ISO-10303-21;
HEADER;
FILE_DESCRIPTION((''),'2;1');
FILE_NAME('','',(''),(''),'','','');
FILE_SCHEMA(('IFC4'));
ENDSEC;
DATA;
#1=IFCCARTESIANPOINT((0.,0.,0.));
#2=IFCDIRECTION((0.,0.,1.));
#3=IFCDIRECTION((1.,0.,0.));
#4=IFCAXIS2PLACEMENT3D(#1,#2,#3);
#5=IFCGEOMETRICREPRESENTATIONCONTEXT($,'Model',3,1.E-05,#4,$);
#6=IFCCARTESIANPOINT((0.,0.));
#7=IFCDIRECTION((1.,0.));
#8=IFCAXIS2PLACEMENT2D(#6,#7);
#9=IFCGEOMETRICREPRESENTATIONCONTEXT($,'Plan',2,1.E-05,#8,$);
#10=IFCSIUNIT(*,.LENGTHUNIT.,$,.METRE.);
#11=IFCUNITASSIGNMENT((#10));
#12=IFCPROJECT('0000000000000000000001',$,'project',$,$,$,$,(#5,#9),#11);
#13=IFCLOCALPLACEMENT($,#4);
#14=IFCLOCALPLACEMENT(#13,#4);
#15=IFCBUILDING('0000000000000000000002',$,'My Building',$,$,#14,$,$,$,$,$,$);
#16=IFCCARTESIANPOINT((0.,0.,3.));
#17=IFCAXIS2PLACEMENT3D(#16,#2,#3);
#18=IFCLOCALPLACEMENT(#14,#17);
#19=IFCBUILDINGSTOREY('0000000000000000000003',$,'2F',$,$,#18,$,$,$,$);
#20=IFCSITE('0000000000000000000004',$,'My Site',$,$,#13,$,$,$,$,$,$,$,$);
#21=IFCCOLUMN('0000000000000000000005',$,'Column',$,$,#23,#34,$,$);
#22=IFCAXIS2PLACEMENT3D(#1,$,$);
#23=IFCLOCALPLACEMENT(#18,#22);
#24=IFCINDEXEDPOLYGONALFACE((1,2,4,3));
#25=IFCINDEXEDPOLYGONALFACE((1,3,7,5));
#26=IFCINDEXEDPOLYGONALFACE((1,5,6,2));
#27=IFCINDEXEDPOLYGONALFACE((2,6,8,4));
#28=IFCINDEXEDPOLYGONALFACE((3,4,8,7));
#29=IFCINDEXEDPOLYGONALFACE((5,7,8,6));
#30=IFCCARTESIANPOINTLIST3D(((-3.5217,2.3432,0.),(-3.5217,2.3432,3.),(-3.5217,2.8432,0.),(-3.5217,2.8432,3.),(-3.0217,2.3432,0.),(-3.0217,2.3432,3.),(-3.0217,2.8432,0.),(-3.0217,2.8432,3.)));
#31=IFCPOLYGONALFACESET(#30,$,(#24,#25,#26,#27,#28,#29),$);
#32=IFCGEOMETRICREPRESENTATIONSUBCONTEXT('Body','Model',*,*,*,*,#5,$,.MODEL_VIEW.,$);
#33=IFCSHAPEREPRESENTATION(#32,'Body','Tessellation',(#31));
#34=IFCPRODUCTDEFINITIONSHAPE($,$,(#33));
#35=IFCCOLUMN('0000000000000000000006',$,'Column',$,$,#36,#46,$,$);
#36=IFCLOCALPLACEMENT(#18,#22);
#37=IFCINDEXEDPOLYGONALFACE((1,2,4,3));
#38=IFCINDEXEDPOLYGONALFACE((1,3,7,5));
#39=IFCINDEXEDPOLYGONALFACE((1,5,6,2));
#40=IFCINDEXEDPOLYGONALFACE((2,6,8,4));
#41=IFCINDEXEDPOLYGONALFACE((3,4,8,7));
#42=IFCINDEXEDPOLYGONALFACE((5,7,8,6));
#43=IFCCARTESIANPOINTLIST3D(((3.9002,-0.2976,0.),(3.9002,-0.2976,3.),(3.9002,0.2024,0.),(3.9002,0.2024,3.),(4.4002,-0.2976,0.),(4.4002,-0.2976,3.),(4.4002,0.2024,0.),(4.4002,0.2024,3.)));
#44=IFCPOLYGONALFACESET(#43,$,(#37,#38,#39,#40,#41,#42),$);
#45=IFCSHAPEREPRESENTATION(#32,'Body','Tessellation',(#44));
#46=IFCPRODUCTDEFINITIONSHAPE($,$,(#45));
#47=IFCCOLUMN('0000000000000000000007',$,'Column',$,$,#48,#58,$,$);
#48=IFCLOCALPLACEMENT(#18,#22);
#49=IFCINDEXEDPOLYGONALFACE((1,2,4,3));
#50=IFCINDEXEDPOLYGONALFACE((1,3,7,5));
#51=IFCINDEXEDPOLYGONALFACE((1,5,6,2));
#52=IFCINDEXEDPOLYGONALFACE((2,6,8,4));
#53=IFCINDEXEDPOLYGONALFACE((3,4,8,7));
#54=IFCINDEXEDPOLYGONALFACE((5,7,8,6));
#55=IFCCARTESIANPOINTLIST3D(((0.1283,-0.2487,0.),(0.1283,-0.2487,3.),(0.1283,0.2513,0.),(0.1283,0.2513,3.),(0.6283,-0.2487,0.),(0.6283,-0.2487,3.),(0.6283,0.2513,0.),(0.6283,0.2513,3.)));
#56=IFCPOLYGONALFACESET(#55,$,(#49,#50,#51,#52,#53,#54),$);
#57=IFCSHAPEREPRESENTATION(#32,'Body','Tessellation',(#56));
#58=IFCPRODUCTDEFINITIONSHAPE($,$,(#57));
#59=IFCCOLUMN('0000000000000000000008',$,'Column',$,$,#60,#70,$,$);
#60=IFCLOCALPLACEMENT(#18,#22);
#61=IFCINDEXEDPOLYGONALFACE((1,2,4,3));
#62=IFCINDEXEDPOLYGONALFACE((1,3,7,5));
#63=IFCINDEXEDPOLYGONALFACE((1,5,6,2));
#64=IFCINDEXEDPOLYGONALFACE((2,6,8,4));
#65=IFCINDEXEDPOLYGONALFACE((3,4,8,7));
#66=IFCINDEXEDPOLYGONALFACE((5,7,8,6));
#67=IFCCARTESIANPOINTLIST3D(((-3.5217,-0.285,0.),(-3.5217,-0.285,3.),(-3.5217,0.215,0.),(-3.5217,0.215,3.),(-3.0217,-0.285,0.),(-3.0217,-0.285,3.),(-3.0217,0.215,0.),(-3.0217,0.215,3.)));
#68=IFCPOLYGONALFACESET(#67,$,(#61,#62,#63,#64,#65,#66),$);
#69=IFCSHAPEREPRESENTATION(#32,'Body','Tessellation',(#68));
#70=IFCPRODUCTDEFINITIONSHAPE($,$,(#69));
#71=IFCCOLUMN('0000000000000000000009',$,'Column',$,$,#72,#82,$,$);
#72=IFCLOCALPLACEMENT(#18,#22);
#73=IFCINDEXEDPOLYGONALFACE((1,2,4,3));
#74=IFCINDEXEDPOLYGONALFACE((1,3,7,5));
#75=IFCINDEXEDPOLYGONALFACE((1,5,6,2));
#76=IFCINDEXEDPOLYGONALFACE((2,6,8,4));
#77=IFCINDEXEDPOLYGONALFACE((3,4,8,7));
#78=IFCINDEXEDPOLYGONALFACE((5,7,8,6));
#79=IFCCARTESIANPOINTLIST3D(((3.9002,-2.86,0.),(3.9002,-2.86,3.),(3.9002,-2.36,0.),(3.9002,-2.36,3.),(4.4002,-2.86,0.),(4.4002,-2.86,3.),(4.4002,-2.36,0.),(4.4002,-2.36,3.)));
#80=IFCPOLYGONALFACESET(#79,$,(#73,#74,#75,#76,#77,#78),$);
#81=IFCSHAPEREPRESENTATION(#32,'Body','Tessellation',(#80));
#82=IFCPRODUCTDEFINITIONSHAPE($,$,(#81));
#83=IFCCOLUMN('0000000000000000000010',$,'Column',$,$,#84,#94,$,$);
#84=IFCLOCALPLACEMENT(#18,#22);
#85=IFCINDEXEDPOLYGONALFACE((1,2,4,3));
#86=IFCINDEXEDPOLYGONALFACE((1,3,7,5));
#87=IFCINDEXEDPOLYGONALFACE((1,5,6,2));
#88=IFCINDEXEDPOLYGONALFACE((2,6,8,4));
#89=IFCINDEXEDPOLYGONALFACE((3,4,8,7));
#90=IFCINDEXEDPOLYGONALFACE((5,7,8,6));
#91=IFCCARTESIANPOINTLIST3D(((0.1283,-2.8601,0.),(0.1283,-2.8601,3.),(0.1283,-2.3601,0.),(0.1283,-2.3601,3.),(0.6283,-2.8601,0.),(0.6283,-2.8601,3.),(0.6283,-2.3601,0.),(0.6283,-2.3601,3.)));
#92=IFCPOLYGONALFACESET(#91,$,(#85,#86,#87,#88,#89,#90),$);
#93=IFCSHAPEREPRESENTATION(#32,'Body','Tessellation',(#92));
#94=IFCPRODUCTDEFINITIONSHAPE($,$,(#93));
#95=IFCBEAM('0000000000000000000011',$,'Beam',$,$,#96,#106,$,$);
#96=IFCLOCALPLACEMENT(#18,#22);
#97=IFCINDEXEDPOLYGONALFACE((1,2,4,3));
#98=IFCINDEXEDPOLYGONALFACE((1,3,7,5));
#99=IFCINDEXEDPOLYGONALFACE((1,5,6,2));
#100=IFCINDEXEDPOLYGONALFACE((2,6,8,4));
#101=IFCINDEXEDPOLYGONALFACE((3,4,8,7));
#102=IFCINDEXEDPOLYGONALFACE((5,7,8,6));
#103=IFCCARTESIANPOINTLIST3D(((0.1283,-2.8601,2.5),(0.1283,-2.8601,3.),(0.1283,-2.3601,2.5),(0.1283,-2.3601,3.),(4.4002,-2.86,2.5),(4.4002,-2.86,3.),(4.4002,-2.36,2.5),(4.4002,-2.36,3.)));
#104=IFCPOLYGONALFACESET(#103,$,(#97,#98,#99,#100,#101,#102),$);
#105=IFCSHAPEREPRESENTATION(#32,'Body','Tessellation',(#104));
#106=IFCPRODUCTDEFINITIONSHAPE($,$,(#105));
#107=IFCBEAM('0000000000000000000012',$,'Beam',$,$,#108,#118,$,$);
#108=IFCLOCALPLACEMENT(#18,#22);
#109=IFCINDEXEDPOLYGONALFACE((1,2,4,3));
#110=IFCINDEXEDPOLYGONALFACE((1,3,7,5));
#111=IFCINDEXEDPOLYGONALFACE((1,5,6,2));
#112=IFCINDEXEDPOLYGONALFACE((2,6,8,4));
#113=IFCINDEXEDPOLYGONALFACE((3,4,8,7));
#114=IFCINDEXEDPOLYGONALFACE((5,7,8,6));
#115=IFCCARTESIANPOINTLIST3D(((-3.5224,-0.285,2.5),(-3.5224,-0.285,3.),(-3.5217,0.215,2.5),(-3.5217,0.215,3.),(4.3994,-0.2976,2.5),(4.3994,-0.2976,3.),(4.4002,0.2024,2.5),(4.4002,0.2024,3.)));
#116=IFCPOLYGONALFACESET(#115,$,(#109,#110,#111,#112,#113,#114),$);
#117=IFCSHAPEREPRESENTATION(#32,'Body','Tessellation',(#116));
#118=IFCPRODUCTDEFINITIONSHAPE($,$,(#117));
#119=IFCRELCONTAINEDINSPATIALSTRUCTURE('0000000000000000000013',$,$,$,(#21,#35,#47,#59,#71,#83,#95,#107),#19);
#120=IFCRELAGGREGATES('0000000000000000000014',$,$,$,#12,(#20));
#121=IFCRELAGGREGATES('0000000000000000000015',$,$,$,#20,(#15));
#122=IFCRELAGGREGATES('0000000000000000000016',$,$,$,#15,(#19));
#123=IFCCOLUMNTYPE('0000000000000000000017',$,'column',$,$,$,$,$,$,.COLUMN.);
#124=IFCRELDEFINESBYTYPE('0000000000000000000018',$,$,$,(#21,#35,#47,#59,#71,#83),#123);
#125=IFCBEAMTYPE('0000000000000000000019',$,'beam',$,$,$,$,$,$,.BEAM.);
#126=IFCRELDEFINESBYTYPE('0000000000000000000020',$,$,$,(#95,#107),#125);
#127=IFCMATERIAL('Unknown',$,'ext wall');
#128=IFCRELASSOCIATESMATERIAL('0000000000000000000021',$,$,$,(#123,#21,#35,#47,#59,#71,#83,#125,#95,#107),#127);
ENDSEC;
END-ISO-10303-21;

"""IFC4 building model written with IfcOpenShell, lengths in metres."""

from ifc_helpers import new_model, si_unit, frame, origin_with_axes, origin_2d_with_axis, place, context, subcontext, project, spatial, rectangle, extrude, material, material_profile, profile_set, profile_usage, type_object, element, save


model = new_model("IFC4")

# Units and contexts
model_context = context("Model", 3, precision=1e-05, world=origin_with_axes())
plan_context = context("Plan", 2, precision=1e-05, world=origin_2d_with_axis())
body_context_1 = subcontext(model_context, "Body", "Model", "MODEL_VIEW")
ifc_project = project(units=[si_unit("LENGTHUNIT", "METRE")], contexts=[model_context, plan_context])

# Site, building, storey
site_placement = place(None, origin_with_axes())
site = spatial("IfcSite", under=ifc_project, at=site_placement, Name="My Site")
building_placement = place(site_placement, origin_with_axes())
building = spatial("IfcBuilding", under=site, at=building_placement, Name="My Building")
storey_placement = place(building_placement, frame((0.0, 0.0, 3.0), z_axis=(0.0, 0.0, 1.0), x_axis=(1.0, 0.0, 0.0)))
storey = spatial("IfcBuildingStorey", under=building, at=storey_placement, Name="2F")

# Columns
ifc_material = material(Name="Unknown", Category="ext wall")
ifc_material_profile_1 = material_profile(ifc_material, rectangle(XDim=0.5, YDim=0.5))
ifc_profile_set_1 = profile_set([ifc_material_profile_1])
ifc_profile_usage_1 = profile_usage(ifc_profile_set_1, cardinal=5)
column_type = type_object("IfcColumnType", Name="column", PredefinedType="COLUMN", material=ifc_profile_set_1)
column_1_placement = place(storey_placement, frame((-3.2717, 2.5932, 0.0), z_axis=(0.0, 0.0, 1.0), x_axis=(1.0, 0.0, 0.0)))
element("IfcColumn", 1, at=column_1_placement, inside=storey, type_object=column_type, material=ifc_profile_usage_1, Name="Column", context=body_context_1, shape_type="SweptSolid", body=[
    extrude(rectangle(XDim=0.5, YDim=0.5), origin_with_axes(), (0.0, 0.0, 1.0), 3.0),
])
ifc_profile_usage_2 = profile_usage(ifc_profile_set_1, cardinal=5)
column_2_placement = place(storey_placement, frame((4.1502, -0.0476, 0.0), z_axis=(0.0, 0.0, 1.0), x_axis=(1.0, 0.0, 0.0)))
element("IfcColumn", 2, at=column_2_placement, inside=storey, type_object=column_type, material=ifc_profile_usage_2, Name="Column", context=body_context_1, shape_type="SweptSolid", body=[
    extrude(rectangle(XDim=0.5, YDim=0.5), origin_with_axes(), (0.0, 0.0, 1.0), 3.0),
])
ifc_profile_usage_3 = profile_usage(ifc_profile_set_1, cardinal=5)
column_3_placement = place(storey_placement, frame((0.3783, 0.0013, 0.0), z_axis=(0.0, 0.0, 1.0), x_axis=(1.0, 0.0, 0.0)))
element("IfcColumn", 3, at=column_3_placement, inside=storey, type_object=column_type, material=ifc_profile_usage_3, Name="Column", context=body_context_1, shape_type="SweptSolid", body=[
    extrude(rectangle(XDim=0.5, YDim=0.5), origin_with_axes(), (0.0, 0.0, 1.0), 3.0),
])
ifc_profile_usage_4 = profile_usage(ifc_profile_set_1, cardinal=5)
column_4_placement = place(storey_placement, frame((-3.2717, -0.035, 0.0), z_axis=(0.0, 0.0, 1.0), x_axis=(1.0, 0.0, 0.0)))
element("IfcColumn", 4, at=column_4_placement, inside=storey, type_object=column_type, material=ifc_profile_usage_4, Name="Column", context=body_context_1, shape_type="SweptSolid", body=[
    extrude(rectangle(XDim=0.5, YDim=0.5), origin_with_axes(), (0.0, 0.0, 1.0), 3.0),
])
ifc_profile_usage_5 = profile_usage(ifc_profile_set_1, cardinal=5)
column_5_placement = place(storey_placement, frame((4.1502, -2.61, 0.0), z_axis=(0.0, 0.0, 1.0), x_axis=(1.0, 0.0, 0.0)))
element("IfcColumn", 5, at=column_5_placement, inside=storey, type_object=column_type, material=ifc_profile_usage_5, Name="Column", context=body_context_1, shape_type="SweptSolid", body=[
    extrude(rectangle(XDim=0.5, YDim=0.5), origin_with_axes(), (0.0, 0.0, 1.0), 3.0),
])
ifc_profile_usage_6 = profile_usage(ifc_profile_set_1, cardinal=5)
column_6_placement = place(storey_placement, frame((0.3783, -2.6101, 0.0), z_axis=(0.0, 0.0, 1.0), x_axis=(1.0, 0.0, 0.0)))
element("IfcColumn", 6, at=column_6_placement, inside=storey, type_object=column_type, material=ifc_profile_usage_6, Name="Column", context=body_context_1, shape_type="SweptSolid", body=[
    extrude(rectangle(XDim=0.5, YDim=0.5), origin_with_axes(), (0.0, 0.0, 1.0), 3.0),
])

# Beams
ifc_material_profile_2 = material_profile(ifc_material, rectangle(XDim=0.5, YDim=0.5))
ifc_profile_set_2 = profile_set([ifc_material_profile_2])
ifc_profile_usage_7 = profile_usage(ifc_profile_set_2, cardinal=7)
beam_type = type_object("IfcBeamType", Name="beam", PredefinedType="BEAM", material=ifc_profile_set_2)
beam_1_placement = place(storey_placement, frame((0.1283, -2.3601, 3.0), z_axis=(1.0, 0.000018, 0.0), x_axis=(-0.000018, 1.0, 0.0)))
element("IfcBeam", 7, at=beam_1_placement, inside=storey, type_object=beam_type, material=ifc_profile_usage_7, Name="Beam", context=body_context_1, shape_type="SweptSolid", body=[
    extrude(rectangle(XDim=0.5, YDim=0.5), frame((-0.25, -0.25, 0.0), z_axis=(0.0, 0.0, 1.0), x_axis=(1.0, 0.0, 0.0)), (0.0, 0.0, 1.0), 4.2718),
])
ifc_profile_usage_8 = profile_usage(ifc_profile_set_2, cardinal=7)
beam_2_placement = place(storey_placement, frame((-3.5217, 0.215, 3.0), z_axis=(0.999999, -0.001585, 0.0), x_axis=(0.001585, 0.999999, 0.0)))
element("IfcBeam", 8, at=beam_2_placement, inside=storey, type_object=beam_type, material=ifc_profile_usage_8, Name="Beam", context=body_context_1, shape_type="SweptSolid", body=[
    extrude(rectangle(XDim=0.5, YDim=0.5), frame((-0.25, -0.25, 0.0), z_axis=(0.0, 0.0, 1.0), x_axis=(1.0, 0.0, 0.0)), (0.0, 0.0, 1.0), 7.9218),
])

save(model, "model.ifc")
